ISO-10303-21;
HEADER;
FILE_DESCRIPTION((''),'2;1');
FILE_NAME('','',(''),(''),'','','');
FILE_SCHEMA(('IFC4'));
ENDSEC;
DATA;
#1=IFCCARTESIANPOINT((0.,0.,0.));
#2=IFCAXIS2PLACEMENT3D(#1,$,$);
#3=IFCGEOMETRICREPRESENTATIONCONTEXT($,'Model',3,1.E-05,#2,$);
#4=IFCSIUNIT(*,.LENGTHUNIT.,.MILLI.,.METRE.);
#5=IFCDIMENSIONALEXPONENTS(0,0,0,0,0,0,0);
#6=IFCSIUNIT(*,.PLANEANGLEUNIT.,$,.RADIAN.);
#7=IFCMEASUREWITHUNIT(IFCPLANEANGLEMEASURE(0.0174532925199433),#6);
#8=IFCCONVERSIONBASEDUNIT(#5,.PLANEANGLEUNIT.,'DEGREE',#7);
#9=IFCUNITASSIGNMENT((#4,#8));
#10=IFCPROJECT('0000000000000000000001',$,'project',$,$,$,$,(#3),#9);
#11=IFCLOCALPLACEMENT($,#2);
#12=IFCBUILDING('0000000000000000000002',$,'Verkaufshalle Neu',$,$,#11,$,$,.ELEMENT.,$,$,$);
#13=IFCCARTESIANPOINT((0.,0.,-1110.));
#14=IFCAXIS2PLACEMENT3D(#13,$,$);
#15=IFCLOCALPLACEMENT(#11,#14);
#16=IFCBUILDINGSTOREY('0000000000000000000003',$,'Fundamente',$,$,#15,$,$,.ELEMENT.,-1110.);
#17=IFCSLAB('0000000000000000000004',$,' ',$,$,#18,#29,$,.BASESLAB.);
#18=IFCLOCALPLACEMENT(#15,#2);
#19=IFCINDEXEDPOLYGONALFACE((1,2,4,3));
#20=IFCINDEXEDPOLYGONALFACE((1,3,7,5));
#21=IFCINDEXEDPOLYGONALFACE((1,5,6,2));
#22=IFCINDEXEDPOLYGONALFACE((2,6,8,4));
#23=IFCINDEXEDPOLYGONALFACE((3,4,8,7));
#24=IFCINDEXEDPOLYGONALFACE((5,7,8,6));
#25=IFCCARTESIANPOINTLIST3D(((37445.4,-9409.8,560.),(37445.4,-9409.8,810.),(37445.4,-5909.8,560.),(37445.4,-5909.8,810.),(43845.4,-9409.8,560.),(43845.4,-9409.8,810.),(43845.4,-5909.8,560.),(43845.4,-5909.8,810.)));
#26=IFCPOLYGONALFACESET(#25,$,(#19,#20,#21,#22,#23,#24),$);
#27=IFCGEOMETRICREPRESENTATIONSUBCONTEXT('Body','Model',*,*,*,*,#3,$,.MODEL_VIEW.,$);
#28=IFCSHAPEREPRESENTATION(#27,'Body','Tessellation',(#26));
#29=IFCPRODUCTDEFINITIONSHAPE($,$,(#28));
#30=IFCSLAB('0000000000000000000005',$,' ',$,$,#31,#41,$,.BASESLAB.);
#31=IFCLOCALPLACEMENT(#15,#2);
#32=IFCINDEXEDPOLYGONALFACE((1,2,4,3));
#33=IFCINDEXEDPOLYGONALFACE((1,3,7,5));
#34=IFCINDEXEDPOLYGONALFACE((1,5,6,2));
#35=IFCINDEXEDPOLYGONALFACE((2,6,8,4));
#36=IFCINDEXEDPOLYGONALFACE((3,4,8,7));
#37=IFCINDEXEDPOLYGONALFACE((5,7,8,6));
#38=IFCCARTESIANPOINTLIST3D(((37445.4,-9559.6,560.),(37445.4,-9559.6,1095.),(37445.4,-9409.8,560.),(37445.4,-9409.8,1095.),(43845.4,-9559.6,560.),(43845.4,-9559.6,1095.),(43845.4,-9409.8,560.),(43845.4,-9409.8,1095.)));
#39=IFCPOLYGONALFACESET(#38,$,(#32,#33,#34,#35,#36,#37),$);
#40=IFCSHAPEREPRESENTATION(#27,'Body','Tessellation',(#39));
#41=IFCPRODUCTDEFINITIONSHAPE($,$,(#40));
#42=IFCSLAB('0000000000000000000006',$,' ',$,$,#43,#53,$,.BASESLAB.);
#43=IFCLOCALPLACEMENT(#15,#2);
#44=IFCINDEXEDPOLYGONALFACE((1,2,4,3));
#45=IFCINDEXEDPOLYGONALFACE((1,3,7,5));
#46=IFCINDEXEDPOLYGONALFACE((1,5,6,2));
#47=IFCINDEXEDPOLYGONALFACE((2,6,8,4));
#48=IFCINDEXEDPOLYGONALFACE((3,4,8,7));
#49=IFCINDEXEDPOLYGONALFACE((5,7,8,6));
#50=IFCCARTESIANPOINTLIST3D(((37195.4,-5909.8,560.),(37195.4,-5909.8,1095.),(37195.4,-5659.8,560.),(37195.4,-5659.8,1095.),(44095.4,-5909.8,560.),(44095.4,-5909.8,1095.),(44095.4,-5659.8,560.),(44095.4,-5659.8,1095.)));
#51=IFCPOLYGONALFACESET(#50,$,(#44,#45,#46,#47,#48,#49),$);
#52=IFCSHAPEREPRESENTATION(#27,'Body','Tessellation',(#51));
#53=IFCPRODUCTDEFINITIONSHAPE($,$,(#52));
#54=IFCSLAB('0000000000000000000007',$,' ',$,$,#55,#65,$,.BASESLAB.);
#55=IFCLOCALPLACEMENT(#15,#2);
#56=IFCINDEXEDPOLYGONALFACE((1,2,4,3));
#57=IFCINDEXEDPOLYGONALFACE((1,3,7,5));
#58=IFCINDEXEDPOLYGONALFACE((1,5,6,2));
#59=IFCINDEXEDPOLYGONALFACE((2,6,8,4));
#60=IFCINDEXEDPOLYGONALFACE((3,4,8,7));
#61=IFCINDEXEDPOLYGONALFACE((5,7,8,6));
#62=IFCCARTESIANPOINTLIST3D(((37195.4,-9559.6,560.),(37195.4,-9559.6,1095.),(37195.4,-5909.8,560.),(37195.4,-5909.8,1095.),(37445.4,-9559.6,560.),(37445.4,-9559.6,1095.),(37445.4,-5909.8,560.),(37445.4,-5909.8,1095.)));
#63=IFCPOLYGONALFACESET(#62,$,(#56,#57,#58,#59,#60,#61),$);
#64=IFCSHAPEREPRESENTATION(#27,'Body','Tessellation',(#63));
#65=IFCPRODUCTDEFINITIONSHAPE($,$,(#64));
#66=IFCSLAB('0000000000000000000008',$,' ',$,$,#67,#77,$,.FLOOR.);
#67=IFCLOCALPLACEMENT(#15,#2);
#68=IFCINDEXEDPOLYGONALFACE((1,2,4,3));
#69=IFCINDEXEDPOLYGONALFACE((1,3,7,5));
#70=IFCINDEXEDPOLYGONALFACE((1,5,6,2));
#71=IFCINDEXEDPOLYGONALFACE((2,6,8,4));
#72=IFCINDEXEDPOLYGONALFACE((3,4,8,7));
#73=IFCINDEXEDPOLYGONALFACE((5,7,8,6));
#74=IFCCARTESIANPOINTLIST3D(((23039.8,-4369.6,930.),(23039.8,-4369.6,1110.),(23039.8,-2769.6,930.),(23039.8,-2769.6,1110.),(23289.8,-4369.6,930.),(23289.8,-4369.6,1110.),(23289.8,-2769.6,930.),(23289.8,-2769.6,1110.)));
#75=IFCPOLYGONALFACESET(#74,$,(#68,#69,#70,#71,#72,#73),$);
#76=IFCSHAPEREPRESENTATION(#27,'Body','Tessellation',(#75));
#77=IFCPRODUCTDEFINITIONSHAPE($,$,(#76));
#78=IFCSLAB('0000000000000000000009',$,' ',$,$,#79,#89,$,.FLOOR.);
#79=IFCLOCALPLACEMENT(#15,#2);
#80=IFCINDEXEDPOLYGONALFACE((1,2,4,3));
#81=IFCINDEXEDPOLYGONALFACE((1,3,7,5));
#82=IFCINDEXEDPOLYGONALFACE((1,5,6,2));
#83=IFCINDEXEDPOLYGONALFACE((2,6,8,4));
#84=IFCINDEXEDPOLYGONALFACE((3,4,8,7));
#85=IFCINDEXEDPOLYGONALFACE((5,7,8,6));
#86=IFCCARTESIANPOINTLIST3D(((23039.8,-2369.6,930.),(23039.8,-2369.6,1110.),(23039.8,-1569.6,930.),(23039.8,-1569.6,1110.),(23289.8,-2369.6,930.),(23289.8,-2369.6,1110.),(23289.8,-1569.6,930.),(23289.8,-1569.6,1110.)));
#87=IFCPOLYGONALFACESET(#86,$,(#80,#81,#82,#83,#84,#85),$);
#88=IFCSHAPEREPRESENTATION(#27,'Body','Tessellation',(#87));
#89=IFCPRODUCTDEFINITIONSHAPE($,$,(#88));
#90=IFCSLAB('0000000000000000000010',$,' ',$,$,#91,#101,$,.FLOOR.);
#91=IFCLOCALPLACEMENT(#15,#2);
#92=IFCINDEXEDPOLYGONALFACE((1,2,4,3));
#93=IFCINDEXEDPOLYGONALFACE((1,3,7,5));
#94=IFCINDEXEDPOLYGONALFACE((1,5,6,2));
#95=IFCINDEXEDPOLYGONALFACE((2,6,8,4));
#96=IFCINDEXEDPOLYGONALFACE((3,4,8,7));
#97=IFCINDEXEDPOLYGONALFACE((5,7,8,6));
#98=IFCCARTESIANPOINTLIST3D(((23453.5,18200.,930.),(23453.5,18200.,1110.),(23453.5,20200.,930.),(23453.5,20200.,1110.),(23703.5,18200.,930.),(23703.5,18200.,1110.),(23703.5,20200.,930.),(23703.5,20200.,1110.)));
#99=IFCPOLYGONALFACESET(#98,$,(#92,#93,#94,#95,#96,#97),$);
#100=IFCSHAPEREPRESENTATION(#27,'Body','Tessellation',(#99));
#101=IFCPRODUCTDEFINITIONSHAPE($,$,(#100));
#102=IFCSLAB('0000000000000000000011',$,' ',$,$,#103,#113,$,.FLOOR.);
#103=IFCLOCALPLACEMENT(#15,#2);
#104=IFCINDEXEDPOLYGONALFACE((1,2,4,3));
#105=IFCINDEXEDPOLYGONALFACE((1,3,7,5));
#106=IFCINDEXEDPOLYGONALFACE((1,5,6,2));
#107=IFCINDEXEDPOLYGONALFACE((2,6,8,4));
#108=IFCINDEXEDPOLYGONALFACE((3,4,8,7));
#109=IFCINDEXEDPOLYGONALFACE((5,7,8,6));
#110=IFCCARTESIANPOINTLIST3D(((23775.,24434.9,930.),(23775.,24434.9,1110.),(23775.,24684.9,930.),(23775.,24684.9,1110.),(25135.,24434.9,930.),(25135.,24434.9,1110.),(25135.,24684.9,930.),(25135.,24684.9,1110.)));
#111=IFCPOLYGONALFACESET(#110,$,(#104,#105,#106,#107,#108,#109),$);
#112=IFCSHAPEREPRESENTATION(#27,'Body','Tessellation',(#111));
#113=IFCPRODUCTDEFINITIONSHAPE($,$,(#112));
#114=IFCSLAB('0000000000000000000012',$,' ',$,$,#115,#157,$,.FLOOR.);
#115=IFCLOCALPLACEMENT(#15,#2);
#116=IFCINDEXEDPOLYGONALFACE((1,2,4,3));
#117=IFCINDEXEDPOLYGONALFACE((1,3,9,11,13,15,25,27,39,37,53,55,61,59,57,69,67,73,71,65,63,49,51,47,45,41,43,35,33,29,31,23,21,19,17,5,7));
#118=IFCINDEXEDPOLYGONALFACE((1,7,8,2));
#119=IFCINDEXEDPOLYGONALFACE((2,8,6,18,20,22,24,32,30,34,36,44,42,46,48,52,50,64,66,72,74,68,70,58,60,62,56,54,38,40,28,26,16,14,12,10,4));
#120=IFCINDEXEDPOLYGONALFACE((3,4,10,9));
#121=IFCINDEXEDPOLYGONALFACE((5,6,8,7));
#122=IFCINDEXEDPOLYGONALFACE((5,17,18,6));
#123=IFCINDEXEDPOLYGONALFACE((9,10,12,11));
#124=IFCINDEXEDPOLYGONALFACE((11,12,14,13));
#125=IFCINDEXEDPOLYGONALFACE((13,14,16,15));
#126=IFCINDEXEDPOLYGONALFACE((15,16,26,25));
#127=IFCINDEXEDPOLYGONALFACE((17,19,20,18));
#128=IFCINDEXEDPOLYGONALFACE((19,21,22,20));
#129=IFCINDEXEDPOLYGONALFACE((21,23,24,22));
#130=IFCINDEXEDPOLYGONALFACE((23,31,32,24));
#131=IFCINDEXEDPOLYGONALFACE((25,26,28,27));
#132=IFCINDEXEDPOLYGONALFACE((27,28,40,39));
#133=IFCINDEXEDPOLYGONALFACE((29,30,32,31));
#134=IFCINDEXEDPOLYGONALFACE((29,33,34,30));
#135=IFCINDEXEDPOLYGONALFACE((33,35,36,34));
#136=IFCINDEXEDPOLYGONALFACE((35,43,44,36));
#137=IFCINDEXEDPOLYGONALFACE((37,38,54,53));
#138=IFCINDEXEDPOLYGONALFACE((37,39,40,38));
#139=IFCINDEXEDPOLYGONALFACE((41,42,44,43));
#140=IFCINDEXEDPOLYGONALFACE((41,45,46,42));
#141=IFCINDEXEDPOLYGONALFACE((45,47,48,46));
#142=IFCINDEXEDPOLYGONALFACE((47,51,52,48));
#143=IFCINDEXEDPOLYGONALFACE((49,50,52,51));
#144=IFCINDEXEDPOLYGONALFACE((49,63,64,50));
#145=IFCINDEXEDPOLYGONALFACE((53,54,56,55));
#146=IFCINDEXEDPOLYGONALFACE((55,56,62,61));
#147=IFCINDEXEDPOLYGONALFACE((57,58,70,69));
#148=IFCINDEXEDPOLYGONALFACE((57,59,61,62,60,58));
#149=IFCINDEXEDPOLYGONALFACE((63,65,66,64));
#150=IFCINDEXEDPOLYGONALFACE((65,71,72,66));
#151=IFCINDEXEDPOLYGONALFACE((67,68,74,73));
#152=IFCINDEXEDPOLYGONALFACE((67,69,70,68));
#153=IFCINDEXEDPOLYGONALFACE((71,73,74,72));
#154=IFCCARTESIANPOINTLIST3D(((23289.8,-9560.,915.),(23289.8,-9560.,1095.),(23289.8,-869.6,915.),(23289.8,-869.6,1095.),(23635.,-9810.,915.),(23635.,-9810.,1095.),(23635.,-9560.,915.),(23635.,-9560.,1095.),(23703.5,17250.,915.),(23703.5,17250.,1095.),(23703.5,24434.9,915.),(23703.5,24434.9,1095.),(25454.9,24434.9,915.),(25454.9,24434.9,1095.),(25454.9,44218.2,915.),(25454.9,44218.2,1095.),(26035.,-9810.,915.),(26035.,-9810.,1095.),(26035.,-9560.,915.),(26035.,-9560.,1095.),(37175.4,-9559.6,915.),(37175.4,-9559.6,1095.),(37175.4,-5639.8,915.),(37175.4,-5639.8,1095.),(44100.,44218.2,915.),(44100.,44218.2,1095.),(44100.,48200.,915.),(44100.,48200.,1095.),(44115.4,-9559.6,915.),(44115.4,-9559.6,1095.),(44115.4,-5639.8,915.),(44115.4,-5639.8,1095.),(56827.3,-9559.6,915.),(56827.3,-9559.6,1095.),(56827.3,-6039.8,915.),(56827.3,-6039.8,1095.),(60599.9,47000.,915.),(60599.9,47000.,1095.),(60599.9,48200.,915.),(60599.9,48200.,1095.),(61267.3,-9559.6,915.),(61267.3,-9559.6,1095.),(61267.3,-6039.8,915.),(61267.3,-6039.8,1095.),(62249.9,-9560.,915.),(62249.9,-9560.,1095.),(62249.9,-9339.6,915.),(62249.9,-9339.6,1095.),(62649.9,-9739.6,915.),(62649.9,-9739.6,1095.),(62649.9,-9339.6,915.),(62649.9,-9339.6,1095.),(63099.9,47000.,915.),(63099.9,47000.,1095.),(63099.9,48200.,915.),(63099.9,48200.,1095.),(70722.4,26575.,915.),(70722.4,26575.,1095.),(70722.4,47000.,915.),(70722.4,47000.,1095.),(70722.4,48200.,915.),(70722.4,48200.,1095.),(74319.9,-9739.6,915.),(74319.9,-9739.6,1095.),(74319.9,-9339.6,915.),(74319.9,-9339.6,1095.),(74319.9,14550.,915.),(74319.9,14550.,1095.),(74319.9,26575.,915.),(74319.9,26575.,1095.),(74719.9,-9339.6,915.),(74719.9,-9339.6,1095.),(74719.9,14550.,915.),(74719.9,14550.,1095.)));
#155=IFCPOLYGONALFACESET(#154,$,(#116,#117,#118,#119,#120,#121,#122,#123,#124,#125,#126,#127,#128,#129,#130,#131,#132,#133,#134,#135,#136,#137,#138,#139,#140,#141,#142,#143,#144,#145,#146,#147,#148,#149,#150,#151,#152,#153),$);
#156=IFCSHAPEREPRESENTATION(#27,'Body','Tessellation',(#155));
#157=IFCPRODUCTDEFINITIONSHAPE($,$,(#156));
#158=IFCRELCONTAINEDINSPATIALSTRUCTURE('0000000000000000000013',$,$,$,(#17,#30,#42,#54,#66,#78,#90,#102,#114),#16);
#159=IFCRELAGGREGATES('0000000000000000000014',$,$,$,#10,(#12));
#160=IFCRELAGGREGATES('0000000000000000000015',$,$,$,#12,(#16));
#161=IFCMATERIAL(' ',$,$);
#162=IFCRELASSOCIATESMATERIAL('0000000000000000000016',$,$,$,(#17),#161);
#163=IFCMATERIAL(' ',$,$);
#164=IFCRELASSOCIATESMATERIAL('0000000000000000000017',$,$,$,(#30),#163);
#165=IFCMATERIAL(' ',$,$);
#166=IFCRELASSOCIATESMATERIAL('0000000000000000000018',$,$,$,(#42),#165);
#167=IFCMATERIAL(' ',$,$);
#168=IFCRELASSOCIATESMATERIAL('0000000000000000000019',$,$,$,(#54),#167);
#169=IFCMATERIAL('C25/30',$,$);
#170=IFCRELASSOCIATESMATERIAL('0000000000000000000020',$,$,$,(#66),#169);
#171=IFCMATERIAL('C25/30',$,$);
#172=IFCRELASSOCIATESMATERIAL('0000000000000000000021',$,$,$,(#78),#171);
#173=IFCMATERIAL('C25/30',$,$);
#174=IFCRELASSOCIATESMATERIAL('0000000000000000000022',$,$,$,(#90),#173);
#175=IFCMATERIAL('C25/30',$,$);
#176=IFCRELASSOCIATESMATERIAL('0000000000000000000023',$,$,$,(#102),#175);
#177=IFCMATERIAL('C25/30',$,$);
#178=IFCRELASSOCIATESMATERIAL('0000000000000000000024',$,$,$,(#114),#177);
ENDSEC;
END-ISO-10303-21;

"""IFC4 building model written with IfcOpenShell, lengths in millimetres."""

from ifc_helpers import new_model, entity, si_unit, converted_unit, frame, frame_2d, origin, origin_with_axes, place, context, subcontext, project, spatial, polyline, rectangle, outline, extrude, material, element, save


model = new_model("IFC4")

# Units and contexts
model_context = context("Model", 3, precision=1e-05, world=origin())
body_context = subcontext(model_context, "Body", "Model", "MODEL_VIEW")
ifc_project = project(units=[si_unit("LENGTHUNIT", "METRE", prefix="MILLI"), converted_unit("PLANEANGLEUNIT", "DEGREE", entity("IfcPlaneAngleMeasure", 0.0174532925199433), si_unit("PLANEANGLEUNIT", "RADIAN"), dimensions=[0, 0, 0, 0, 0, 0, 0])], contexts=[model_context])

# Building, storey
building_placement = place(None, origin())
building = spatial("IfcBuilding", under=ifc_project, at=building_placement, Name="Verkaufshalle Neu", CompositionType="ELEMENT")
storey_placement = place(building_placement, frame((0.0, 0.0, -1110.0)))
storey = spatial("IfcBuildingStorey", under=building, at=storey_placement, Name="Fundamente", CompositionType="ELEMENT", Elevation=-1110.0)

# Slabs
ifc_material_1 = material(Name=" ")
slab_1_placement = place(storey_placement, frame((37445.4, -9409.8, 560.0)))
element("IfcSlab", 1, at=slab_1_placement, inside=storey, material=ifc_material_1, Name=" ", PredefinedType="BASESLAB", context=body_context, shape_type="SweptSolid", body=[
    extrude(rectangle(XDim=6400.0, YDim=3500.0, at=frame_2d((3200.0, 1750.0), x_axis=(1.0, 0.0))), origin_with_axes(), (0.0, 0.0, 1.0), 250.0),
])
ifc_material_2 = material(Name=" ")
slab_2_placement = place(storey_placement, frame((37445.4, -9559.6, 560.0)))
element("IfcSlab", 2, at=slab_2_placement, inside=storey, material=ifc_material_2, Name=" ", PredefinedType="BASESLAB", context=body_context, shape_type="SweptSolid", body=[
    extrude(rectangle(XDim=149.7, YDim=6400.0, at=frame_2d((-3200.0, 74.9), x_axis=(0.0, 1.0))), frame((6400.0, 0.0, 0.0), z_axis=(0.0, 0.0, 1.0), x_axis=(1.0, 0.0, 0.0)), (0.0, 0.0, 1.0), 535.0),
])
ifc_material_3 = material(Name=" ")
slab_3_placement = place(storey_placement, frame((37195.4, -5909.8, 560.0)))
element("IfcSlab", 3, at=slab_3_placement, inside=storey, material=ifc_material_3, Name=" ", PredefinedType="BASESLAB", context=body_context, shape_type="SweptSolid", body=[
    extrude(rectangle(XDim=6900.0, YDim=250.0, at=frame_2d((3450.0, 125.0), x_axis=(1.0, 0.0))), origin_with_axes(), (0.0, 0.0, 1.0), 535.0),
])
ifc_material_4 = material(Name=" ")
slab_4_placement = place(storey_placement, frame((37195.4, -9559.6, 560.0)))
element("IfcSlab", 4, at=slab_4_placement, inside=storey, material=ifc_material_4, Name=" ", PredefinedType="BASESLAB", context=body_context, shape_type="SweptSolid", body=[
    extrude(rectangle(XDim=250.0, YDim=3649.7, at=frame_2d((-125.0, -1824.9), x_axis=(-1.0, 0.0))), frame((250.0, 3649.7, 0.0), z_axis=(0.0, 0.0, 1.0), x_axis=(1.0, 0.0, 0.0)), (0.0, 0.0, 1.0), 535.0),
])
ifc_material_5 = material(Name="C25/30")
slab_5_placement = place(storey_placement, frame((23039.8, -4369.6, 930.0)))
element("IfcSlab", 5, at=slab_5_placement, inside=storey, material=ifc_material_5, Name=" ", PredefinedType="FLOOR", context=body_context, shape_type="SweptSolid", body=[
    extrude(rectangle(XDim=1600.0, YDim=250.0, at=frame_2d((125.0, -800.0), x_axis=(0.0, -1.0))), frame((0.0, 1600.0, 0.0), z_axis=(0.0, 0.0, 1.0), x_axis=(1.0, 0.0, 0.0)), (0.0, 0.0, 1.0), 180.0),
])
ifc_material_6 = material(Name="C25/30")
slab_6_placement = place(storey_placement, frame((23039.8, -2369.6, 930.0)))
element("IfcSlab", 6, at=slab_6_placement, inside=storey, material=ifc_material_6, Name=" ", PredefinedType="FLOOR", context=body_context, shape_type="SweptSolid", body=[
    extrude(rectangle(XDim=800.0, YDim=250.0, at=frame_2d((125.0, -400.0), x_axis=(0.0, -1.0))), frame((0.0, 800.0, 0.0), z_axis=(0.0, 0.0, 1.0), x_axis=(1.0, 0.0, 0.0)), (0.0, 0.0, 1.0), 180.0),
])
ifc_material_7 = material(Name="C25/30")
slab_7_placement = place(storey_placement, frame((23453.5, 18200.0, 930.0)))
element("IfcSlab", 7, at=slab_7_placement, inside=storey, material=ifc_material_7, Name=" ", PredefinedType="FLOOR", context=body_context, shape_type="SweptSolid", body=[
    extrude(rectangle(XDim=2000.0, YDim=250.0, at=frame_2d((125.0, -1000.0), x_axis=(0.0, -1.0))), frame((0.0, 2000.0, 0.0), z_axis=(0.0, 0.0, 1.0), x_axis=(1.0, 0.0, 0.0)), (0.0, 0.0, 1.0), 180.0),
])
ifc_material_8 = material(Name="C25/30")
slab_8_placement = place(storey_placement, frame((23775.0, 24434.9, 930.0)))
element("IfcSlab", 8, at=slab_8_placement, inside=storey, material=ifc_material_8, Name=" ", PredefinedType="FLOOR", context=body_context, shape_type="SweptSolid", body=[
    extrude(rectangle(XDim=250.0, YDim=1360.0, at=frame_2d((680.0, -125.0), x_axis=(0.0, -1.0))), frame((0.0, 250.0, 0.0), z_axis=(0.0, 0.0, 1.0), x_axis=(1.0, 0.0, 0.0)), (0.0, 0.0, 1.0), 180.0),
])
ifc_material_9 = material(Name="C25/30")
slab_9_placement = place(storey_placement, frame((23289.8, -9810.0, 915.0)))
element("IfcSlab", 9, at=slab_9_placement, inside=storey, material=ifc_material_9, Name=" ", PredefinedType="FLOOR", context=body_context, shape_type="SweptSolid", body=[
    extrude(outline(polyline([(51430.2, 470.4), (51430.2, 24360.0), (51030.2, 24360.0), (51030.2, 36385.0), (47432.7, 36385.0), (47432.7, 56810.0), (47432.7, 56810.0), (47432.7, 58010.0), (39810.2, 58010.0), (39810.2, 56810.0), (37310.2, 56810.0), (37310.2, 58010.0), (20810.2, 58010.0), (20810.2, 54028.2), (2165.2, 54028.2), (2165.2, 34244.9), (413.8, 34244.9), (413.8, 27060.0), (0.0, 8940.4), (0.0, 250.0), (345.2, 250.0), (345.2, 0.0), (2745.2, 0.0), (2745.2, 250.0), (13885.6, 250.4), (13885.6, 4170.2), (20825.6, 4170.2), (20825.6, 250.4), (33537.6, 250.4), (33537.6, 3770.2), (37977.6, 3770.2), (37977.6, 250.4), (38960.2, 250.0), (38960.2, 470.4), (39360.2, 470.4), (39360.2, 70.4), (51030.2, 70.4), (51030.2, 470.4), (51430.2, 470.4)])), origin_with_axes(), (0.0, 0.0, 1.0), 180.0),
])

save(model, "model.ifc")
